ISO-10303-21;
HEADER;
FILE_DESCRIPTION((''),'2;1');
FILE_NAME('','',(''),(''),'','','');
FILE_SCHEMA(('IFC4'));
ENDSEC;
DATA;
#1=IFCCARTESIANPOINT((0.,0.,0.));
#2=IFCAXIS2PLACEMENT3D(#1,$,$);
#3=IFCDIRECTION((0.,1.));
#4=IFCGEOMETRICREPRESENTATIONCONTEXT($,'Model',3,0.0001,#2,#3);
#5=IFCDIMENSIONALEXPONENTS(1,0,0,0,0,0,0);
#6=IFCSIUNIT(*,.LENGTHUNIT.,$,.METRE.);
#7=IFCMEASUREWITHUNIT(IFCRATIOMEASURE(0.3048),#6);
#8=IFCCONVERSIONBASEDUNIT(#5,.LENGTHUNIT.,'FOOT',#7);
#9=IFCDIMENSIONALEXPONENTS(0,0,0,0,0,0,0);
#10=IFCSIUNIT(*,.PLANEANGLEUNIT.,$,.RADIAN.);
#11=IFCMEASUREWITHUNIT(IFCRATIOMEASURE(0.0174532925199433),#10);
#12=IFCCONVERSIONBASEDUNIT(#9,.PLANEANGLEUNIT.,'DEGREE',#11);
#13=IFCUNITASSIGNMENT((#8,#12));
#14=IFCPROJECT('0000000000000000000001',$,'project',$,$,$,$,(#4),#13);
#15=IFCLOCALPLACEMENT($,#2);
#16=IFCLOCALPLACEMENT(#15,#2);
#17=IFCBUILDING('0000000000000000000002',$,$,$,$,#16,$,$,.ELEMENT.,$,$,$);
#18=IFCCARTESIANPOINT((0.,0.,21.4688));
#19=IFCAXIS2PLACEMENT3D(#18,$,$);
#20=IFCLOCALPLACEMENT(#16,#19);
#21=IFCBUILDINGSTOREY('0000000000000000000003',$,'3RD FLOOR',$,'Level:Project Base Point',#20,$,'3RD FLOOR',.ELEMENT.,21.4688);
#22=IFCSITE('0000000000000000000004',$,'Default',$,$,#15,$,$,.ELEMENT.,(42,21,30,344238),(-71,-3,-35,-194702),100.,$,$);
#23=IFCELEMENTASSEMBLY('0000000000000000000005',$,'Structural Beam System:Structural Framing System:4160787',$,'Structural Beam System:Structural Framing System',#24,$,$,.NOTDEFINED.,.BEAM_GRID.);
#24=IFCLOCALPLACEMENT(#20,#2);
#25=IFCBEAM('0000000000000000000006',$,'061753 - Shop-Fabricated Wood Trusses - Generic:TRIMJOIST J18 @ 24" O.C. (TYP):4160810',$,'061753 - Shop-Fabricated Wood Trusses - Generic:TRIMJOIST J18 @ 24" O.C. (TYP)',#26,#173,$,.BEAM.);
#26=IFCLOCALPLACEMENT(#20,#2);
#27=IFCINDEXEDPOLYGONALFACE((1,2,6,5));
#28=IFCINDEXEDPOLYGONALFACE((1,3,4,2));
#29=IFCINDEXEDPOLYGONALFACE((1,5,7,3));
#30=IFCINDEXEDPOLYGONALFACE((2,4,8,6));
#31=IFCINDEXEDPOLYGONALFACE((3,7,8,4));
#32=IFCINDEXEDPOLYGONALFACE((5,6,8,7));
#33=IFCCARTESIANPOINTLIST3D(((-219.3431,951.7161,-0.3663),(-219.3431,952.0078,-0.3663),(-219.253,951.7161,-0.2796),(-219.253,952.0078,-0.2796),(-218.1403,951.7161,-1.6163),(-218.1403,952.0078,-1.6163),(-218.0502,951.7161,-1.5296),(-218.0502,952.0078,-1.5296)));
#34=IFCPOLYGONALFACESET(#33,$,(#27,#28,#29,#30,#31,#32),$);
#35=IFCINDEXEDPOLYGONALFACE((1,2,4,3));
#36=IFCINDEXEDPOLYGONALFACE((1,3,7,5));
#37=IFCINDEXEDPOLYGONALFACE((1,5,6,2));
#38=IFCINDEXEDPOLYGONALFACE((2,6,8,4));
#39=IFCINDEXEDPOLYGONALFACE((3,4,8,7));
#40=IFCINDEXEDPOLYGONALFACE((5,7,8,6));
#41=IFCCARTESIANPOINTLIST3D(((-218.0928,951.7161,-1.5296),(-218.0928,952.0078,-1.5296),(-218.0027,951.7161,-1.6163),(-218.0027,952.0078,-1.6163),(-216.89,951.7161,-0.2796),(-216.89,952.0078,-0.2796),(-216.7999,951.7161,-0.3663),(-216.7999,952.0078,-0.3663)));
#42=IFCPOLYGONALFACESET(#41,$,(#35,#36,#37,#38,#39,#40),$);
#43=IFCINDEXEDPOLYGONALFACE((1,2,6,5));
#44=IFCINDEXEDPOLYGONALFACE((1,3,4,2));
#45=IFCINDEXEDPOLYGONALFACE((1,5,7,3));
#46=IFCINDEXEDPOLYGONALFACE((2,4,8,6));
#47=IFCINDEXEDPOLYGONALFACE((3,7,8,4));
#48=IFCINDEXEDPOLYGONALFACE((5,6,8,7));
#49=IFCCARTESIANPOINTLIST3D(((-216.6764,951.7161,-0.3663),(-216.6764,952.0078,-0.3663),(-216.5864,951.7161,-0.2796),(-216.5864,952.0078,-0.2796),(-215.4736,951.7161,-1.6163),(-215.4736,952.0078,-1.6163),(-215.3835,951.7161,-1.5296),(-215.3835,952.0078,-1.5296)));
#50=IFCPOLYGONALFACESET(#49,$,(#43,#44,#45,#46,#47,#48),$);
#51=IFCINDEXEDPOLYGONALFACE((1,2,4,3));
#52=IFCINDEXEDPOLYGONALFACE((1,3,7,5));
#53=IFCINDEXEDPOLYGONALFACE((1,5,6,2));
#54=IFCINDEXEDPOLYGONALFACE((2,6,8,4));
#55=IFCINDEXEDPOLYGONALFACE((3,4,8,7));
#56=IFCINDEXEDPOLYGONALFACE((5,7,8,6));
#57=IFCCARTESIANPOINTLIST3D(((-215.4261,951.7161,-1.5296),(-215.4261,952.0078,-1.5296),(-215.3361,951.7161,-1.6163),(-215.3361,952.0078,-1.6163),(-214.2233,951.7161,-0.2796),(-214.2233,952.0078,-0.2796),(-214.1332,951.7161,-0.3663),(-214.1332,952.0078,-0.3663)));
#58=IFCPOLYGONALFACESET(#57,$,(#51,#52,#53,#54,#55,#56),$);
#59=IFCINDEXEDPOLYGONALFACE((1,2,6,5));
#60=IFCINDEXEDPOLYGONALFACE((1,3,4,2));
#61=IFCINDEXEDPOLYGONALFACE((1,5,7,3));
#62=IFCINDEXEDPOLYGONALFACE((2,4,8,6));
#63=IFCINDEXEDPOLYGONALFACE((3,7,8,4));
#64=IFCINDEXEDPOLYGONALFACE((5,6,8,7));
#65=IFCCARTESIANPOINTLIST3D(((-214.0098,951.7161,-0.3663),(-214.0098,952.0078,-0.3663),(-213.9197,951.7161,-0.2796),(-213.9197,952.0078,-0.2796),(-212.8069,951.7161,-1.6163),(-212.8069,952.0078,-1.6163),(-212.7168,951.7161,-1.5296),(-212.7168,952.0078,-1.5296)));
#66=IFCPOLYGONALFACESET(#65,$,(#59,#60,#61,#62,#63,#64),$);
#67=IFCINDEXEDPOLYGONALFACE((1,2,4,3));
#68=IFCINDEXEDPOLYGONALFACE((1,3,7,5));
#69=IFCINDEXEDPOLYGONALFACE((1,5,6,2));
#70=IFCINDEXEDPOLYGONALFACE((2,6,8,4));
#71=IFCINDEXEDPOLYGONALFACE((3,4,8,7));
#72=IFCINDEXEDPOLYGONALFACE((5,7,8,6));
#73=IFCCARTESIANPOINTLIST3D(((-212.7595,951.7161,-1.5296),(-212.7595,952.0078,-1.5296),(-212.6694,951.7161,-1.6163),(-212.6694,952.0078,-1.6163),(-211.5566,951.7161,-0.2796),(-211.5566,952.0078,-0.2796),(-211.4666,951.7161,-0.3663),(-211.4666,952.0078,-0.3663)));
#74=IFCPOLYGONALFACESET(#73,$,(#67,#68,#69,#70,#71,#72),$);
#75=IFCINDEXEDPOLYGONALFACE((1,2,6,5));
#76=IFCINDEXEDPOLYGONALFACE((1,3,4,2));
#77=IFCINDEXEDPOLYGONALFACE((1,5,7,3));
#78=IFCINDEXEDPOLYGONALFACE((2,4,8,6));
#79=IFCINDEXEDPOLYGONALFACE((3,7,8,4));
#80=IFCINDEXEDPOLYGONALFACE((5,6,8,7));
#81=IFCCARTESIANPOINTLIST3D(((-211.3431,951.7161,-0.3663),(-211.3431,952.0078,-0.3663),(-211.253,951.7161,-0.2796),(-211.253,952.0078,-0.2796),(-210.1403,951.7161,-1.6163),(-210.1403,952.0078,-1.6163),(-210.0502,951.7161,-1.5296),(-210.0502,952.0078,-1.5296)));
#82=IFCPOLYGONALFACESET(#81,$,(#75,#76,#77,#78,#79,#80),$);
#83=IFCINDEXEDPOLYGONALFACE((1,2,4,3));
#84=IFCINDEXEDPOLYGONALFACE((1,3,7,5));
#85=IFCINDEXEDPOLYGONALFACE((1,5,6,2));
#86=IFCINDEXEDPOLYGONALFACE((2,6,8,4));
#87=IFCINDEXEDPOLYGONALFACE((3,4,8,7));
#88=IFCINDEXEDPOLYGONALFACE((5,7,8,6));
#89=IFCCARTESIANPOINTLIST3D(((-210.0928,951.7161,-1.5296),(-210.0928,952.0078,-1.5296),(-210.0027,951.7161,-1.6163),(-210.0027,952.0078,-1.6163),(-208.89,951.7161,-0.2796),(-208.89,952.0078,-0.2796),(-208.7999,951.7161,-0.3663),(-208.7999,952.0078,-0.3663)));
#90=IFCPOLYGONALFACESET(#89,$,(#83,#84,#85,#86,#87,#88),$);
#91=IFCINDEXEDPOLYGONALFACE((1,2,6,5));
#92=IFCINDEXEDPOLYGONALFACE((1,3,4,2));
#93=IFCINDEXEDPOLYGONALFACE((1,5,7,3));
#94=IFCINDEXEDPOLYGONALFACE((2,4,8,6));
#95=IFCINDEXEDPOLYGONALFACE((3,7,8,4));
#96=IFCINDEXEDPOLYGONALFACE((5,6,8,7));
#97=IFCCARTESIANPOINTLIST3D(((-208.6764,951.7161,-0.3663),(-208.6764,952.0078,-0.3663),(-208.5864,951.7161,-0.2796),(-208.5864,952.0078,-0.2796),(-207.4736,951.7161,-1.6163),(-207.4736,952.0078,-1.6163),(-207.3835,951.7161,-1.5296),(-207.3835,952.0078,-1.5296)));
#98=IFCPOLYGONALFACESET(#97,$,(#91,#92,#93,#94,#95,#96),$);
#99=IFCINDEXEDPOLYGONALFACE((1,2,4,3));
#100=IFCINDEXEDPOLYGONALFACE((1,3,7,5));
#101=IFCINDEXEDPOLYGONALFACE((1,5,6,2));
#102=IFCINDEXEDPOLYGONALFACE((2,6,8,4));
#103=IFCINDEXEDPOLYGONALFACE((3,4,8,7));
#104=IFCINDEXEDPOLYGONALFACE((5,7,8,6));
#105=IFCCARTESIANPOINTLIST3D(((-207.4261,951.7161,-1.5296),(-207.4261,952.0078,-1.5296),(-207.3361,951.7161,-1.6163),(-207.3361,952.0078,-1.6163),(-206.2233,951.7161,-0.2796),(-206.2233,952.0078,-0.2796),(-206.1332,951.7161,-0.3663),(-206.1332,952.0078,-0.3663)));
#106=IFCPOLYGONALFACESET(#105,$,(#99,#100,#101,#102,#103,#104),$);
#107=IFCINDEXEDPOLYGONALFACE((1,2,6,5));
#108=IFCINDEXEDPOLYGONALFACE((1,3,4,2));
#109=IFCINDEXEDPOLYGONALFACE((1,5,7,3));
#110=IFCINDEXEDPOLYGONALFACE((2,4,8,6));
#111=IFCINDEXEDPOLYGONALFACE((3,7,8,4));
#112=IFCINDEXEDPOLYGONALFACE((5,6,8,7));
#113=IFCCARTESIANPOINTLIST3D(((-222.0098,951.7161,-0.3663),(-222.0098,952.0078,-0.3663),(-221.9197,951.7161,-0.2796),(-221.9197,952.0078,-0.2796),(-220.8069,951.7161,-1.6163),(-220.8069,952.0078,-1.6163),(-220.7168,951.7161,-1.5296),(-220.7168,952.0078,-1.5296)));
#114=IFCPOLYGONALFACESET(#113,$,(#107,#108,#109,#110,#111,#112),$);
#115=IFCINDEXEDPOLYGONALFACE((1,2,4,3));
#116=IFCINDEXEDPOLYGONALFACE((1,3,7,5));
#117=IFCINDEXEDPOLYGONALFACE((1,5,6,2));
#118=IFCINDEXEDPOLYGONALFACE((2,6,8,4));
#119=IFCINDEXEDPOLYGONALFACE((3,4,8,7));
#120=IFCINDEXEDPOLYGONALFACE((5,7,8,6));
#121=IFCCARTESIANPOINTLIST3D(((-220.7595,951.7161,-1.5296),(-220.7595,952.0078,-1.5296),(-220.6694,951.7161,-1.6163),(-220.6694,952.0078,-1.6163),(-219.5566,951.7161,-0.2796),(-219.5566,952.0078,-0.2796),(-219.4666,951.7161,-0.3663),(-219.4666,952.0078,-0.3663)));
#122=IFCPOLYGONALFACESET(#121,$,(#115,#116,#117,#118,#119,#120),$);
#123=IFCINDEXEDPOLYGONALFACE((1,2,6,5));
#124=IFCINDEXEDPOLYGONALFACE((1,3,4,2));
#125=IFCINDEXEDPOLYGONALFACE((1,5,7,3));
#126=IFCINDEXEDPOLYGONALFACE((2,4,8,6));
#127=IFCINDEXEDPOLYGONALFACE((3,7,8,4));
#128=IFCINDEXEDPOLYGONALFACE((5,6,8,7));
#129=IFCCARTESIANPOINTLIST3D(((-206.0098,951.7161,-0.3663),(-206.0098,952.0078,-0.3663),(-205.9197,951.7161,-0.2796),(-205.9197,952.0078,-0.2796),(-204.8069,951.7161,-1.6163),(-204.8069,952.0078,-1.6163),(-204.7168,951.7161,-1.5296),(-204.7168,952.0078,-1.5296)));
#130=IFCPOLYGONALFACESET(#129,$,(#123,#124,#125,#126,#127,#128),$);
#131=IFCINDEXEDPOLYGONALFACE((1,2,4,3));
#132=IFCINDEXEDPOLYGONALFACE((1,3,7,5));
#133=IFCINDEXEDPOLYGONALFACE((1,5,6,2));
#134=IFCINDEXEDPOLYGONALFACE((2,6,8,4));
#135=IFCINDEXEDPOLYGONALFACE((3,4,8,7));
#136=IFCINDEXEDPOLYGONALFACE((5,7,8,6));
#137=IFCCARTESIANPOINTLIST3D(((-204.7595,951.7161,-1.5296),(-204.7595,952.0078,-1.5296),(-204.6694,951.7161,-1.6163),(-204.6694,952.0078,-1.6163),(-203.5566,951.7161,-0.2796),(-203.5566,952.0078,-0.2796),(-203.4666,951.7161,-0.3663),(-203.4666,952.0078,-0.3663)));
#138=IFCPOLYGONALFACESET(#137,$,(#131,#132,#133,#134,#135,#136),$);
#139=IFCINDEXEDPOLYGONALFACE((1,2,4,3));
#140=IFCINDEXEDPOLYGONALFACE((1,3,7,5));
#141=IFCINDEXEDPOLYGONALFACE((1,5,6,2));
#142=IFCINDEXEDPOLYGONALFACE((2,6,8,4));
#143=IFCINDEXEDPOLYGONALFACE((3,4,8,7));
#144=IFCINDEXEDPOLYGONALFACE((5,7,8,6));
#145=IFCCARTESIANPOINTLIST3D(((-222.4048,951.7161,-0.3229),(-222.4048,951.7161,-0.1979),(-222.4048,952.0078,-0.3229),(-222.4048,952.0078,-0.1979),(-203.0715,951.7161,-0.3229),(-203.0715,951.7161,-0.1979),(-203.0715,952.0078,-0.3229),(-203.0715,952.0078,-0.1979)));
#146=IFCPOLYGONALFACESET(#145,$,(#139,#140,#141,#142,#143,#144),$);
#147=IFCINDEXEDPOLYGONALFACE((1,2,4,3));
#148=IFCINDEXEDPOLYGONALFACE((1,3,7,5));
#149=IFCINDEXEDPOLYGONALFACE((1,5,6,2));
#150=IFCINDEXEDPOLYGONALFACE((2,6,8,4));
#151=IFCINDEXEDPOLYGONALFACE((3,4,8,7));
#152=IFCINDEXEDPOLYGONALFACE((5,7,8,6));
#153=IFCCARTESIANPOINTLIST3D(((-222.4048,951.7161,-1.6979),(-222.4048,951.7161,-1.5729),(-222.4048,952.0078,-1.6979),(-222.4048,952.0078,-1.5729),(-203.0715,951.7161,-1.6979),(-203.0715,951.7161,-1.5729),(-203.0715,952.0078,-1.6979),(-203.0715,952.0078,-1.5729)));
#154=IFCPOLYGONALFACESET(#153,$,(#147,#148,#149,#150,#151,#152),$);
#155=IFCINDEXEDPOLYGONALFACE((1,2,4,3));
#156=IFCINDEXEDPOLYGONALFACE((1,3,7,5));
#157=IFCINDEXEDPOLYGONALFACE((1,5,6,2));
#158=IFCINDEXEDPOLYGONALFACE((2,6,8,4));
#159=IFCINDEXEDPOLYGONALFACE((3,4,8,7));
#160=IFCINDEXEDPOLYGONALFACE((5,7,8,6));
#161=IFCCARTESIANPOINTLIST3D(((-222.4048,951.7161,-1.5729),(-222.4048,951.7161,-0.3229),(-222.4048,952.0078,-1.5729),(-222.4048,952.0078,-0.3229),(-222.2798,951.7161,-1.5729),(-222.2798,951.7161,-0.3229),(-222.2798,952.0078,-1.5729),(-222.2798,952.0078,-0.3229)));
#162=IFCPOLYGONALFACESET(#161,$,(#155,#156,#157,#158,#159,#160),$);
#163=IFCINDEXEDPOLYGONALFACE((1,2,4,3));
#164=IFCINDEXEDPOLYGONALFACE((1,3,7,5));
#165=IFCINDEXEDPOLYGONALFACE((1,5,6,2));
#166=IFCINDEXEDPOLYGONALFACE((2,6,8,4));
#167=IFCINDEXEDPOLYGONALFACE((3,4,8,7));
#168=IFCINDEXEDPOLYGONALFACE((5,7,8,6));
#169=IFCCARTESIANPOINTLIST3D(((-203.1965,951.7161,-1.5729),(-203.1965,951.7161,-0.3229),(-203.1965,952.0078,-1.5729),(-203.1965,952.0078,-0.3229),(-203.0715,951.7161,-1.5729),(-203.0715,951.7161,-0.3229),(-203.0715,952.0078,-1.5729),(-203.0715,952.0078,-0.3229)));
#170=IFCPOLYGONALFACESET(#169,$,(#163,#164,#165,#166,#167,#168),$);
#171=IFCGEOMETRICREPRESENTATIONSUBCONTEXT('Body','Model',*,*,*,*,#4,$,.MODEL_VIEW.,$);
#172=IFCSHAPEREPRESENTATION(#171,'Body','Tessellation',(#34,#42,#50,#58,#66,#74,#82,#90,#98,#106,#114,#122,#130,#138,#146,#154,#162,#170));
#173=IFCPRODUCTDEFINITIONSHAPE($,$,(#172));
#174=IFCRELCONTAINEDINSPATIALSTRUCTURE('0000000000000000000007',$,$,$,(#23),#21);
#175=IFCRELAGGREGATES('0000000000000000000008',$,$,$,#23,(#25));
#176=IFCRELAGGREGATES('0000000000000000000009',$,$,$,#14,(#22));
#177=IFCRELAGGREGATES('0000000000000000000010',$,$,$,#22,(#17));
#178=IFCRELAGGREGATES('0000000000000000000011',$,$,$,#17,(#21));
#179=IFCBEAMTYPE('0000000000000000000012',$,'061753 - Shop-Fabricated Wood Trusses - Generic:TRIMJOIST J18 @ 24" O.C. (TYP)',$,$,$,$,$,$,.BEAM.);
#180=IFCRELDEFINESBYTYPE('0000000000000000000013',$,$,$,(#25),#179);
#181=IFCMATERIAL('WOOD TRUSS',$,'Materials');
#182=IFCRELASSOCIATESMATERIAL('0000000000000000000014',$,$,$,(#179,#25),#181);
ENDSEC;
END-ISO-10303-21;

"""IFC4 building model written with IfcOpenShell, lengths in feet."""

from ifc_helpers import new_model, entity, si_unit, converted_unit, direction, frame, frame_2d, origin, origin_2d_with_axis, place, context, subcontext, project, spatial, rectangle, extrude, source, transform, mapped, material, material_profile, profile_set, profile_usage, type_object, type_shapes, element, aggregate, save


model = new_model("IFC4")

# Units and contexts
model_context = context("Model", 3, precision=0.0001, world=origin(), true_north=direction((0.0, 1.0)))
body_context = subcontext(model_context, "Body", "Model", "MODEL_VIEW")
ifc_project = project(units=[converted_unit("LENGTHUNIT", "FOOT", entity("IfcRatioMeasure", 0.3048), si_unit("LENGTHUNIT", "METRE"), dimensions=[1, 0, 0, 0, 0, 0, 0]), converted_unit("PLANEANGLEUNIT", "DEGREE", entity("IfcRatioMeasure", 0.0174532925199433), si_unit("PLANEANGLEUNIT", "RADIAN"), dimensions=[0, 0, 0, 0, 0, 0, 0])], contexts=[model_context])

# Site, building, storey
site_placement = place(None, origin())
site = spatial("IfcSite", under=ifc_project, at=site_placement, Name="Default", CompositionType="ELEMENT", RefLatitude=(42, 21, 30, 344238), RefLongitude=(-71, -3, -35, -194702), RefElevation=100.0)
building_placement = place(site_placement, origin())
building = spatial("IfcBuilding", under=site, at=building_placement, CompositionType="ELEMENT")
storey_placement = place(building_placement, frame((0.0, 0.0, 21.4688)))
storey = spatial("IfcBuildingStorey", under=building, at=storey_placement, Name="3RD FLOOR", ObjectType="Level:Project Base Point", LongName="3RD FLOOR", CompositionType="ELEMENT", Elevation=21.4688)

# Element assembly, beam
ifc_material_1 = material(Name="WOOD TRUSS", Category="Materials")
ifc_material_profile_1 = material_profile(ifc_material_1, rectangle(XDim=1.7347, YDim=0.125, at=frame_2d((0.0, 0.0), x_axis=(1.0, 0.0))), Name="TRIMJOIST J18 @ 24\" O.C. (TYP)")
ifc_material_profile_2 = material_profile(ifc_material_1, rectangle(XDim=1.7347, YDim=0.125, at=frame_2d((0.0, 0.0), x_axis=(1.0, 0.0))), Name="TRIMJOIST J18 @ 24\" O.C. (TYP)")
ifc_material_profile_3 = material_profile(ifc_material_1, rectangle(XDim=1.7347, YDim=0.125, at=frame_2d((0.0, 0.0), x_axis=(1.0, 0.0))), Name="TRIMJOIST J18 @ 24\" O.C. (TYP)")
ifc_material_profile_4 = material_profile(ifc_material_1, rectangle(XDim=1.7347, YDim=0.125, at=frame_2d((0.0, 0.0), x_axis=(1.0, 0.0))), Name="TRIMJOIST J18 @ 24\" O.C. (TYP)")
ifc_material_profile_5 = material_profile(ifc_material_1, rectangle(XDim=1.7347, YDim=0.125, at=frame_2d((0.0, 0.0), x_axis=(1.0, 0.0))), Name="TRIMJOIST J18 @ 24\" O.C. (TYP)")
ifc_material_profile_6 = material_profile(ifc_material_1, rectangle(XDim=1.7347, YDim=0.125, at=frame_2d((0.0, 0.0), x_axis=(1.0, 0.0))), Name="TRIMJOIST J18 @ 24\" O.C. (TYP)")
ifc_material_profile_7 = material_profile(ifc_material_1, rectangle(XDim=1.7347, YDim=0.125, at=frame_2d((0.0, 0.0), x_axis=(1.0, 0.0))), Name="TRIMJOIST J18 @ 24\" O.C. (TYP)")
ifc_material_profile_8 = material_profile(ifc_material_1, rectangle(XDim=1.7347, YDim=0.125, at=frame_2d((0.0, 0.0), x_axis=(1.0, 0.0))), Name="TRIMJOIST J18 @ 24\" O.C. (TYP)")
ifc_material_profile_9 = material_profile(ifc_material_1, rectangle(XDim=1.7347, YDim=0.125, at=frame_2d((0.0, 0.0), x_axis=(1.0, 0.0))), Name="TRIMJOIST J18 @ 24\" O.C. (TYP)")
ifc_material_profile_10 = material_profile(ifc_material_1, rectangle(XDim=1.7347, YDim=0.125, at=origin_2d_with_axis()), Name="TRIMJOIST J18 @ 24\" O.C. (TYP)")
ifc_material_profile_11 = material_profile(ifc_material_1, rectangle(XDim=0.125, YDim=0.2917, at=origin_2d_with_axis()), Name="TRIMJOIST J18 @ 24\" O.C. (TYP)")
ifc_material_profile_12 = material_profile(ifc_material_1, rectangle(XDim=0.125, YDim=0.2917, at=origin_2d_with_axis()), Name="TRIMJOIST J18 @ 24\" O.C. (TYP)")
ifc_material_profile_13 = material_profile(ifc_material_1, rectangle(XDim=1.25, YDim=0.2917, at=origin_2d_with_axis()), Name="TRIMJOIST J18 @ 24\" O.C. (TYP)")
ifc_material_profile_14 = material_profile(ifc_material_1, rectangle(XDim=1.25, YDim=0.2917, at=origin_2d_with_axis()), Name="TRIMJOIST J18 @ 24\" O.C. (TYP)")
ifc_profile_set_1 = profile_set([ifc_material_profile_1, ifc_material_profile_2, ifc_material_profile_3, ifc_material_profile_4, ifc_material_profile_5, ifc_material_profile_6, ifc_material_profile_7, ifc_material_profile_8, ifc_material_profile_9, ifc_material_profile_10, ifc_material_profile_11, ifc_material_profile_12, ifc_material_profile_13, ifc_material_profile_14], Name="TRIMJOIST J18 @ 24\" O.C. (TYP)")
beam_type_1 = type_object("IfcBeamType", Name="061753 - Shop-Fabricated Wood Trusses - Generic:TRIMJOIST J18 @ 24\" O.C. (TYP)", PredefinedType="BEAM", material=ifc_profile_set_1)
shared_shape_1 = source(origin(), body_context, "Body", "SweptSolid", [
    extrude(rectangle(XDim=1.7347, YDim=0.125, at=frame_2d((0.0, 0.0), x_axis=(1.0, 0.0))), frame((5.9585, -0.1458, 0.0), z_axis=(0.0, 1.0, 0.0), x_axis=(0.693383, 0.0, 0.720569)), (0.0, 0.0, 1.0), 0.2917),
    extrude(rectangle(XDim=1.7347, YDim=0.125, at=origin_2d_with_axis()), frame((4.7082, -0.1458, 0.0), z_axis=(0.0, 1.0, 0.0), x_axis=(0.693383, 0.0, -0.720569)), (0.0, 0.0, 1.0), 0.2917),
    extrude(rectangle(XDim=1.7347, YDim=0.125, at=frame_2d((0.0, 0.0), x_axis=(1.0, 0.0))), frame((3.2918, -0.1458, 0.0), z_axis=(0.0, 1.0, 0.0), x_axis=(0.693383, 0.0, 0.720569)), (0.0, 0.0, 1.0), 0.2917),
    extrude(rectangle(XDim=1.7347, YDim=0.125, at=frame_2d((0.0, 0.0), x_axis=(1.0, 0.0))), frame((2.0415, -0.1458, 0.0), z_axis=(0.0, 1.0, 0.0), x_axis=(0.693383, 0.0, -0.720569)), (0.0, 0.0, 1.0), 0.2917),
    extrude(rectangle(XDim=1.7347, YDim=0.125, at=frame_2d((0.0, 0.0), x_axis=(1.0, 0.0))), frame((0.6251, -0.1458, 0.0), z_axis=(0.0, 1.0, 0.0), x_axis=(0.693383, 0.0, 0.720569)), (0.0, 0.0, 1.0), 0.2917),
    extrude(rectangle(XDim=1.7347, YDim=0.125, at=frame_2d((0.0, 0.0), x_axis=(1.0, 0.0))), frame((-0.6251, -0.1458, 0.0), z_axis=(0.0, 1.0, 0.0), x_axis=(0.693383, 0.0, -0.720569)), (0.0, 0.0, 1.0), 0.2917),
    extrude(rectangle(XDim=1.7347, YDim=0.125, at=frame_2d((0.0, 0.0), x_axis=(1.0, 0.0))), frame((-2.0415, -0.1458, 0.0), z_axis=(0.0, 1.0, 0.0), x_axis=(0.693383, 0.0, 0.720569)), (0.0, 0.0, 1.0), 0.2917),
    extrude(rectangle(XDim=1.7347, YDim=0.125, at=origin_2d_with_axis()), frame((-3.2918, -0.1458, 0.0), z_axis=(0.0, 1.0, 0.0), x_axis=(0.693383, 0.0, -0.720569)), (0.0, 0.0, 1.0), 0.2917),
    extrude(rectangle(XDim=1.7347, YDim=0.125, at=frame_2d((0.0, 0.0), x_axis=(1.0, 0.0))), frame((-4.7082, -0.1458, 0.0), z_axis=(0.0, 1.0, 0.0), x_axis=(0.693383, 0.0, 0.720569)), (0.0, 0.0, 1.0), 0.2917),
    extrude(rectangle(XDim=1.7347, YDim=0.125, at=frame_2d((0.0, 0.0), x_axis=(1.0, 0.0))), frame((-5.9585, -0.1458, 0.0), z_axis=(0.0, 1.0, 0.0), x_axis=(0.693383, 0.0, -0.720569)), (0.0, 0.0, 1.0), 0.2917),
    extrude(rectangle(XDim=1.7347, YDim=0.125, at=frame_2d((0.0, 0.0), x_axis=(1.0, 0.0))), frame((8.6251, -0.1458, 0.0), z_axis=(0.0, 1.0, 0.0), x_axis=(0.693383, 0.0, 0.720569)), (0.0, 0.0, 1.0), 0.2917),
    extrude(rectangle(XDim=1.7347, YDim=0.125, at=origin_2d_with_axis()), frame((7.3749, -0.1458, 0.0), z_axis=(0.0, 1.0, 0.0), x_axis=(0.693383, 0.0, -0.720569)), (0.0, 0.0, 1.0), 0.2917),
    extrude(rectangle(XDim=1.7347, YDim=0.125, at=frame_2d((0.0, 0.0), x_axis=(1.0, 0.0))), frame((-7.3749, -0.1458, 0.0), z_axis=(0.0, 1.0, 0.0), x_axis=(0.693383, 0.0, 0.720569)), (0.0, 0.0, 1.0), 0.2917),
    extrude(rectangle(XDim=1.7347, YDim=0.125, at=origin_2d_with_axis()), frame((-8.6251, -0.1458, 0.0), z_axis=(0.0, 1.0, 0.0), x_axis=(0.693383, 0.0, -0.720569)), (0.0, 0.0, 1.0), 0.2917),
    extrude(rectangle(XDim=0.125, YDim=0.2917, at=origin_2d_with_axis()), frame((-9.6667, 0.0, 0.6875), z_axis=(1.0, 0.0, 0.0), x_axis=(0.0, 0.0, -1.0)), (0.0, 0.0, 1.0), 19.3333),
    extrude(rectangle(XDim=0.125, YDim=0.2917, at=origin_2d_with_axis()), frame((-9.6667, 0.0, -0.6875), z_axis=(1.0, 0.0, 0.0), x_axis=(0.0, 0.0, -1.0)), (0.0, 0.0, 1.0), 19.3333),
    extrude(rectangle(XDim=1.25, YDim=0.2917, at=origin_2d_with_axis()), frame((9.5417, 0.0, 0.0), z_axis=(1.0, 0.0, 0.0), x_axis=(0.0, 0.0, -1.0)), (0.0, 0.0, 1.0), 0.125),
    extrude(rectangle(XDim=1.25, YDim=0.2917, at=origin_2d_with_axis()), frame((-9.6667, 0.0, 0.0), z_axis=(1.0, 0.0, 0.0), x_axis=(0.0, 0.0, -1.0)), (0.0, 0.0, 1.0), 0.125),
])
type_shapes(beam_type_1, [shared_shape_1])
assembly_1_placement = place(storey_placement, origin())
assembly_1 = element("IfcElementAssembly", 1, at=assembly_1_placement, inside=storey, Name="Structural Beam System:Structural Framing System:4160787", ObjectType="Structural Beam System:Structural Framing System", AssemblyPlace="NOTDEFINED", PredefinedType="BEAM_GRID")
ifc_profile_usage_1 = profile_usage(ifc_profile_set_1, cardinal=8)
beam_1_placement = place(assembly_1_placement, frame((-212.7382, 951.8619, -0.9479), z_axis=(0.0, 0.0, 1.0), x_axis=(-1.0, 0.0, 0.0)))
beam_1 = element("IfcBeam", 2, at=beam_1_placement, type_object=beam_type_1, material=ifc_profile_usage_1, Name="061753 - Shop-Fabricated Wood Trusses - Generic:TRIMJOIST J18 @ 24\" O.C. (TYP):4160810", ObjectType="061753 - Shop-Fabricated Wood Trusses - Generic:TRIMJOIST J18 @ 24\" O.C. (TYP)", PredefinedType="BEAM", context=body_context, shape_type="MappedRepresentation", body=[
    mapped(shared_shape_1, transform((0.0, 0.0, 0.0), scale=1.0)),
])
aggregate(assembly_1, [beam_1])

save(model, "model.ifc")
